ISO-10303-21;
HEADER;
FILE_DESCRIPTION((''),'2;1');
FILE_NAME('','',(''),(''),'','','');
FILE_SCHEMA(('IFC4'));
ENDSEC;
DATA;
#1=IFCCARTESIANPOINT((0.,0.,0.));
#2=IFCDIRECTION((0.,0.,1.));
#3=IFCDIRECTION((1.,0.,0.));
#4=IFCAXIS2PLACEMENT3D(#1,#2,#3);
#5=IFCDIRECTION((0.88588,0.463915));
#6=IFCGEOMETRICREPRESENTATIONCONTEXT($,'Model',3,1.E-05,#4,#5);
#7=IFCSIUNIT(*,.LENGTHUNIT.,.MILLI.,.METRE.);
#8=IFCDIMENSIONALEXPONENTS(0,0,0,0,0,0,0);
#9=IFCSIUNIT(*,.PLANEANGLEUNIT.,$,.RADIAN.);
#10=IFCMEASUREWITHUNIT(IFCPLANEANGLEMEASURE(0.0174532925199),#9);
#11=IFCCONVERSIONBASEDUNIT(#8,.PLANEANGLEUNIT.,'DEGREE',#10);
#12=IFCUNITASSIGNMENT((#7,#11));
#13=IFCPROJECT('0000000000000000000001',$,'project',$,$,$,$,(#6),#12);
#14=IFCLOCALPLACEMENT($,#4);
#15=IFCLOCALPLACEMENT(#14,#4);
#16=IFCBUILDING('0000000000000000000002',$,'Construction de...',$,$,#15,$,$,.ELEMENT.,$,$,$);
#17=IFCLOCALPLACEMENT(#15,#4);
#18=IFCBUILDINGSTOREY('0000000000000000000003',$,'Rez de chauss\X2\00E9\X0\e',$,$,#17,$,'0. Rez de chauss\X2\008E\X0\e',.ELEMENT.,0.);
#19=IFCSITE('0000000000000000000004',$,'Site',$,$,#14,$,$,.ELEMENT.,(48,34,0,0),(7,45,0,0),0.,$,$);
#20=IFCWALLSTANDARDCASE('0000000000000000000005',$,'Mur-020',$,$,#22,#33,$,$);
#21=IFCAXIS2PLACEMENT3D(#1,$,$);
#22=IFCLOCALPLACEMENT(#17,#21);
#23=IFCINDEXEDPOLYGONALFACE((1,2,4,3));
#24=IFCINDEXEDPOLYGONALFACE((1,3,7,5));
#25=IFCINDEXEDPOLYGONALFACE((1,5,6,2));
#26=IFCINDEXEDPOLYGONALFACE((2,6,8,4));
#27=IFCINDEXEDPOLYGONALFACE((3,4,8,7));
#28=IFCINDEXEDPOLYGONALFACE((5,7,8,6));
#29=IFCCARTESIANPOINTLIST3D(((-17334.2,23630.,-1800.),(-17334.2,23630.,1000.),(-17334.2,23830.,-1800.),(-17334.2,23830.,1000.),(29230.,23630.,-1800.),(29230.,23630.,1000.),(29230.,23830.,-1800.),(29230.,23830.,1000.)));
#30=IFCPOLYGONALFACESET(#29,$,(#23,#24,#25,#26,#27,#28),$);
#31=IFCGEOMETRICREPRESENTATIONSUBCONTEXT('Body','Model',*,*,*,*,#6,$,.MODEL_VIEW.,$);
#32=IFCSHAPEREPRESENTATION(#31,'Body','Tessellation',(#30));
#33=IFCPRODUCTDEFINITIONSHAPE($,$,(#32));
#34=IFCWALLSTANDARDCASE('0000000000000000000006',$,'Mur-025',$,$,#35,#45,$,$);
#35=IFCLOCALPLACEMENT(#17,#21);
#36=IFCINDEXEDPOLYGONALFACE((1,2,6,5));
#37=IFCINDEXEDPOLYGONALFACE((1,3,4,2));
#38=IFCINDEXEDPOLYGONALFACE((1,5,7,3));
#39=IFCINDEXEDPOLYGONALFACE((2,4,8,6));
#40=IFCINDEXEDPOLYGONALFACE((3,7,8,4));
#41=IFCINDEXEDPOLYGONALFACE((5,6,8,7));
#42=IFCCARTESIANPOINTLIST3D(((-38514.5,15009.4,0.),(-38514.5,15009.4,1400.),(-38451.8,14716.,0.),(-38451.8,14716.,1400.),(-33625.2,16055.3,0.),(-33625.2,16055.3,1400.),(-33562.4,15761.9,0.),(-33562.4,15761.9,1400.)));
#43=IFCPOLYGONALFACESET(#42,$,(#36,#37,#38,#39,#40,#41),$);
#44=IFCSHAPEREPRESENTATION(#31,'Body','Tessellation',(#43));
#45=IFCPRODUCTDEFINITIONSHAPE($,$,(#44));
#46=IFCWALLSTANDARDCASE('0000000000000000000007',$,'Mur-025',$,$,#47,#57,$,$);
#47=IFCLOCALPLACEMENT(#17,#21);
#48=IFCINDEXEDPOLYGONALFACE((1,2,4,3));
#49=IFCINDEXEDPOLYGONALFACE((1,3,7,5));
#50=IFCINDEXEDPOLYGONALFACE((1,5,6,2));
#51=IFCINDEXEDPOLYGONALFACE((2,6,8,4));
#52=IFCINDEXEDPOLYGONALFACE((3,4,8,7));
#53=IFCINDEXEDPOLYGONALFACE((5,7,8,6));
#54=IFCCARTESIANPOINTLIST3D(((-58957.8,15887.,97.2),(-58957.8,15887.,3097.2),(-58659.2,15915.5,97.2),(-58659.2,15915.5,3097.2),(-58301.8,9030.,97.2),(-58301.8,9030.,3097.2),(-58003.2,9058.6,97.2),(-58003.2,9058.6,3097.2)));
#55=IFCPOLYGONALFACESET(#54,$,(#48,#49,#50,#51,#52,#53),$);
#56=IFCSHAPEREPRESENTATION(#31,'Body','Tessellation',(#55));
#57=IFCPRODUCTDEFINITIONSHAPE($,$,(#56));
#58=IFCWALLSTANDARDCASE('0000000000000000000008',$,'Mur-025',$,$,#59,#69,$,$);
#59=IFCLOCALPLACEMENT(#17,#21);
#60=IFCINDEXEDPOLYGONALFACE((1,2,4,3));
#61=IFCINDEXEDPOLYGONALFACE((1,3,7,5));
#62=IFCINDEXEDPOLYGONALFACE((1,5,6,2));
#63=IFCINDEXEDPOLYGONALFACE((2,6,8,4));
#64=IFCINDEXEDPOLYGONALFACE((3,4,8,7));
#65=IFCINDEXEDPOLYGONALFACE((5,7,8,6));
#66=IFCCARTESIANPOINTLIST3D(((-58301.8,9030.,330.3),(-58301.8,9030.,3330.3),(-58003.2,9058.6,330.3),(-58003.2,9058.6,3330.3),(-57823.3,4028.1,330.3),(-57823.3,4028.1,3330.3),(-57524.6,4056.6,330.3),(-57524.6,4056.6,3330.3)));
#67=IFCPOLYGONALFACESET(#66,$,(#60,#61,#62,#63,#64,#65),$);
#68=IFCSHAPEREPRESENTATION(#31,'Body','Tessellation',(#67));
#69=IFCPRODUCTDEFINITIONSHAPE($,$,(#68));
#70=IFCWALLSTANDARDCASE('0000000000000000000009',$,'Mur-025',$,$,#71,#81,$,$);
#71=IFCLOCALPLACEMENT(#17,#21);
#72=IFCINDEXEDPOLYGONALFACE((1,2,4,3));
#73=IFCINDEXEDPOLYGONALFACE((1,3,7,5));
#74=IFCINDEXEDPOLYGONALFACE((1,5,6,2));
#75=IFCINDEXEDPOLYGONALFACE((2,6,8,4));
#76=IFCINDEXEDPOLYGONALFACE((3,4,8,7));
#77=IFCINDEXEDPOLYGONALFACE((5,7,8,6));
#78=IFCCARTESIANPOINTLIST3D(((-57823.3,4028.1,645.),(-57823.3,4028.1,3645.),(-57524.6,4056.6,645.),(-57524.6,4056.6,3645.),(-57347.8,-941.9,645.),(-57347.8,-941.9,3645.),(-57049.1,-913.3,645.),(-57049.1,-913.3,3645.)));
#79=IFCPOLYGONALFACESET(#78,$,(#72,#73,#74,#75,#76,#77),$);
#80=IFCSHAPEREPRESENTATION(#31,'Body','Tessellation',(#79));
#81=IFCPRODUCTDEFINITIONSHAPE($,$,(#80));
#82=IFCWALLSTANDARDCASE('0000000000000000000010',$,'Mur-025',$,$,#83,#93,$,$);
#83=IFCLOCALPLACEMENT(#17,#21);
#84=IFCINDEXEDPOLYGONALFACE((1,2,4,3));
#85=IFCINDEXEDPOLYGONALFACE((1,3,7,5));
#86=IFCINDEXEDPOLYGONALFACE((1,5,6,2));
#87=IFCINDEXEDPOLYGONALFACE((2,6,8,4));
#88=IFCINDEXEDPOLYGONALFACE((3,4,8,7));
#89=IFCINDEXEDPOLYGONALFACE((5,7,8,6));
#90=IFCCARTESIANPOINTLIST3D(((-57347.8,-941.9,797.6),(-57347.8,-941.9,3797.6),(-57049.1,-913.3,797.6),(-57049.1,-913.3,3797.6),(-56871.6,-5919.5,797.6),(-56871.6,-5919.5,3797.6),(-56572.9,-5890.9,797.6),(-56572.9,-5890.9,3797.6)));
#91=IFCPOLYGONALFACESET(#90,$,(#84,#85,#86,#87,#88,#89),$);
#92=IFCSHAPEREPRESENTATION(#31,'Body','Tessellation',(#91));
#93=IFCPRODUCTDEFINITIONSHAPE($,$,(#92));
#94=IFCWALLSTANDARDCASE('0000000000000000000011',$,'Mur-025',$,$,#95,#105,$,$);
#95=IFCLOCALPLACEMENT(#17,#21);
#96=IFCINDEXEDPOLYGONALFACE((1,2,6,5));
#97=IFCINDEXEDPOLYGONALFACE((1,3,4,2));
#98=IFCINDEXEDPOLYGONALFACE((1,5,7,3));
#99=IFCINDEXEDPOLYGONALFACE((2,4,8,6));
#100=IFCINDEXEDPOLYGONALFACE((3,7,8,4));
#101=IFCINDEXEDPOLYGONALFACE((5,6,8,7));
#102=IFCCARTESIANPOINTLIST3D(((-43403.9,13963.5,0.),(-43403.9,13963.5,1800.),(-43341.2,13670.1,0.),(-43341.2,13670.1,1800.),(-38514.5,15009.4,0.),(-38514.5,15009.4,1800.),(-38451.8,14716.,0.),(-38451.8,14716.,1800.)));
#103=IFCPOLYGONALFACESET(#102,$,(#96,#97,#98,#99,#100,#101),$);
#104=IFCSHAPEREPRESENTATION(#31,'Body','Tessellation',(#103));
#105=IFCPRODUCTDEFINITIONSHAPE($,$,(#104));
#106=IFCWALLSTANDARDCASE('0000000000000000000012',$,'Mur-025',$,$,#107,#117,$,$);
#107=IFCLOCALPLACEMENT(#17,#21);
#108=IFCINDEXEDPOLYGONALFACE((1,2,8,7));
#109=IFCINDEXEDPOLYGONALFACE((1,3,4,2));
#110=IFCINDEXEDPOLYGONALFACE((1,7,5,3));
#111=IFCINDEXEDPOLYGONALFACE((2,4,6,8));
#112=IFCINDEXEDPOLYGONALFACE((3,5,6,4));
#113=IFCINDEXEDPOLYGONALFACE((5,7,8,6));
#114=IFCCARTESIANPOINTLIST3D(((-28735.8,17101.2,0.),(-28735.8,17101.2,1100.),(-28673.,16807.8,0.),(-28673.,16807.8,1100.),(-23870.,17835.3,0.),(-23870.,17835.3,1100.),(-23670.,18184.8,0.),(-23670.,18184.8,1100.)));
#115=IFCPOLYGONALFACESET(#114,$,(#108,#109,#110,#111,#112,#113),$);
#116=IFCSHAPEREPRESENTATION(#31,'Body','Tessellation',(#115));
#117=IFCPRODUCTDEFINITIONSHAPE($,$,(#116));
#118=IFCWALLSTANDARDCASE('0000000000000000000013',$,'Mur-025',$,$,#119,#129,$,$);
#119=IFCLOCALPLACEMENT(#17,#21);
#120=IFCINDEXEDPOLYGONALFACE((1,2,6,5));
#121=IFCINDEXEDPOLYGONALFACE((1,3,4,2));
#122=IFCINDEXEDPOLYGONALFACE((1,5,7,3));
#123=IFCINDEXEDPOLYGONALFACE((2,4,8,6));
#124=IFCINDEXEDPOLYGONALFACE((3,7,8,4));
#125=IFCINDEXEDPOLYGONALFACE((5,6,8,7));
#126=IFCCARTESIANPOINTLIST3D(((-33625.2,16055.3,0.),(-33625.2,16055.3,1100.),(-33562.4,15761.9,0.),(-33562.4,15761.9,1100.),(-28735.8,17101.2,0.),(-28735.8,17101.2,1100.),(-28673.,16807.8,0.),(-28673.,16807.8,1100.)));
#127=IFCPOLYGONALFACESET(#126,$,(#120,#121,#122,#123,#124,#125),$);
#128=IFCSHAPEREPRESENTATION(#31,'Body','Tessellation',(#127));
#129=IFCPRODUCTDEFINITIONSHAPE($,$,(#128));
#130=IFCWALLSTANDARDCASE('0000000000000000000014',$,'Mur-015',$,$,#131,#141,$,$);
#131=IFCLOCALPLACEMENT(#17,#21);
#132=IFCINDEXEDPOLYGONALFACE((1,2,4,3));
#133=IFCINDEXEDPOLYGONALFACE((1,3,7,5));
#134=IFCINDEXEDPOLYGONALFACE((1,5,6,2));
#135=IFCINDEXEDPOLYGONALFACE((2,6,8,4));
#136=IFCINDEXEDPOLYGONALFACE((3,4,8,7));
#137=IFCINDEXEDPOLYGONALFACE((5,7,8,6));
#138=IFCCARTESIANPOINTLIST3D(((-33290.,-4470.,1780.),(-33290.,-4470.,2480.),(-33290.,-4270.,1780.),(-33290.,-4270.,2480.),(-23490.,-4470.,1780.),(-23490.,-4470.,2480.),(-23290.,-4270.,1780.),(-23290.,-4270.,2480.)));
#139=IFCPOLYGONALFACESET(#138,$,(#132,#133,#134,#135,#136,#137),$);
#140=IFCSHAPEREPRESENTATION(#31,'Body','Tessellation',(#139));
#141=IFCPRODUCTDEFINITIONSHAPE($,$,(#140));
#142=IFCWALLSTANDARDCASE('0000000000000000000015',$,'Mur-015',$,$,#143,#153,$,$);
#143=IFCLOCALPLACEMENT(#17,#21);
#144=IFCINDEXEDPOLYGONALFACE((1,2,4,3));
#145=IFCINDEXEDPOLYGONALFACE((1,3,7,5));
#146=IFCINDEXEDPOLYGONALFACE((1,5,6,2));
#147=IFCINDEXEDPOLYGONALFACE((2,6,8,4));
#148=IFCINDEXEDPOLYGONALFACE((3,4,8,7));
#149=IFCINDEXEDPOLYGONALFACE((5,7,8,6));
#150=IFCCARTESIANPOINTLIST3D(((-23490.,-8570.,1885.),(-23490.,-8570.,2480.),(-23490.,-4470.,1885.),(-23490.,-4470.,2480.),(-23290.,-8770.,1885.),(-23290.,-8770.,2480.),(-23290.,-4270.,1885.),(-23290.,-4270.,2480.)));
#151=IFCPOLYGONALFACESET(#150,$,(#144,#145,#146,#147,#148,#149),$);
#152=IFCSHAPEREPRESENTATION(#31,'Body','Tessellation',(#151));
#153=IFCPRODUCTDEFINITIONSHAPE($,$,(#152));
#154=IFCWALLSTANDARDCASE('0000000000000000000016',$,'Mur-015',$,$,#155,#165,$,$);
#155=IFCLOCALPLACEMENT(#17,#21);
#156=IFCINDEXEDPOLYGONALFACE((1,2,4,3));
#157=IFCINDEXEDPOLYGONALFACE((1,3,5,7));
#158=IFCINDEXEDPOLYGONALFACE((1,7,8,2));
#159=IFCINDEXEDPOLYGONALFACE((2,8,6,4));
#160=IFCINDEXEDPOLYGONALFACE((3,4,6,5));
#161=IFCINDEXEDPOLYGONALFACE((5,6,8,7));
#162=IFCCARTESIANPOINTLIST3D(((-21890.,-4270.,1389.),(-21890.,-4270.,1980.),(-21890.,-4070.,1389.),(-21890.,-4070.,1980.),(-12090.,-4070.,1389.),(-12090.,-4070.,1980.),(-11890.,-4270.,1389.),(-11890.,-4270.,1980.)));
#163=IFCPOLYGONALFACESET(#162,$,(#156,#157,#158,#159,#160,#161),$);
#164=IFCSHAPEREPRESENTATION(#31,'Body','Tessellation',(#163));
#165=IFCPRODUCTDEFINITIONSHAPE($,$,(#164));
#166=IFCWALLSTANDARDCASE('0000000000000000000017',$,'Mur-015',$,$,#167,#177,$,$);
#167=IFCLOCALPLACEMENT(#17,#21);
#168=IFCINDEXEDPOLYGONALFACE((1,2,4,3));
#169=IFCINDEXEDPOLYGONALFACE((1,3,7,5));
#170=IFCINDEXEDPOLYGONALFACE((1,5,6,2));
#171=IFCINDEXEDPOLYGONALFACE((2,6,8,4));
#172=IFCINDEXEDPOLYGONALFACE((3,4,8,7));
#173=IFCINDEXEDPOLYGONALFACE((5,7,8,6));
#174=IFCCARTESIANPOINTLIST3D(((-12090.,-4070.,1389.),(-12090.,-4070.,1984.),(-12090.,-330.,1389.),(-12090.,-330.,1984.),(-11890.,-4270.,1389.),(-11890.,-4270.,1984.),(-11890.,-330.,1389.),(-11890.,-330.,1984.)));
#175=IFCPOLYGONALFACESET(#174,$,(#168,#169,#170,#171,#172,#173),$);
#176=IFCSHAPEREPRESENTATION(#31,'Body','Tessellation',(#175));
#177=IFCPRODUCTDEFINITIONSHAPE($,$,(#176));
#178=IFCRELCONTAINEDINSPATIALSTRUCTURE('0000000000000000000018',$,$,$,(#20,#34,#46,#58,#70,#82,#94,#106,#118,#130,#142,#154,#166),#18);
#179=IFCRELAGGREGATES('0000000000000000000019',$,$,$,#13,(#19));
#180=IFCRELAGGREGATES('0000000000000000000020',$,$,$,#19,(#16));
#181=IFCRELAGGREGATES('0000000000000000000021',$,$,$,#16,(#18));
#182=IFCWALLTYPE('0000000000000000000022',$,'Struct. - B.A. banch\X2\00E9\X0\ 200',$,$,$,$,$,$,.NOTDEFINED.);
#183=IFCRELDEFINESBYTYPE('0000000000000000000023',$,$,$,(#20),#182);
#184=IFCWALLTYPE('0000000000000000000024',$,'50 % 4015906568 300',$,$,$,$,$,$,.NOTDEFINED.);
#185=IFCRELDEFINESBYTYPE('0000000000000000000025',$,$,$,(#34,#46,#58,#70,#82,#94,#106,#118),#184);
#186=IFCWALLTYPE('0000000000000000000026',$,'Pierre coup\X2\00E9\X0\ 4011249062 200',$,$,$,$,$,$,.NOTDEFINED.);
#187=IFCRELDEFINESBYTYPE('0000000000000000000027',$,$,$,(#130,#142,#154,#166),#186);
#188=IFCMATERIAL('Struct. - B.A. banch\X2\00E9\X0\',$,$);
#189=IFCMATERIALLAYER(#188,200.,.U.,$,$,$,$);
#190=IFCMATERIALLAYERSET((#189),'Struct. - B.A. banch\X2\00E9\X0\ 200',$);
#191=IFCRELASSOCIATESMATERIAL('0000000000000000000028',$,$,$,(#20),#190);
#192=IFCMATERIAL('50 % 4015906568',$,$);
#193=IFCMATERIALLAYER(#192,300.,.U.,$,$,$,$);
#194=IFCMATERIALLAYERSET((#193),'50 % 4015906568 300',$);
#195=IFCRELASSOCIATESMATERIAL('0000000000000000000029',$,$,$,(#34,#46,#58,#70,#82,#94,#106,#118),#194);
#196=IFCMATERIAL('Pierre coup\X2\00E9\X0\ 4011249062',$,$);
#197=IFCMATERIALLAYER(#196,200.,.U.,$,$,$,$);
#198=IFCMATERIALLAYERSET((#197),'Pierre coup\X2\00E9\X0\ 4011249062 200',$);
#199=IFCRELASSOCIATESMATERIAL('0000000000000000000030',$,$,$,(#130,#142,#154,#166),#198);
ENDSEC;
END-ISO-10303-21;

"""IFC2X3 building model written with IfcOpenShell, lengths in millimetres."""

from ifc_helpers import new_model, entity, si_unit, converted_unit, direction, frame, origin_with_axes, place, context, subcontext, project, spatial, polyline, outline, extrude, material, layer, layer_set, layer_usage, type_object, element, save


model = new_model("IFC2X3")

# Units and contexts
model_context = context("Model", 3, precision=1e-05, world=origin_with_axes(), true_north=direction((0.88588, 0.463915)))
body_context = subcontext(model_context, "Body", "Model", "MODEL_VIEW")
ifc_project = project(units=[si_unit("LENGTHUNIT", "METRE", prefix="MILLI"), converted_unit("PLANEANGLEUNIT", "DEGREE", entity("IfcPlaneAngleMeasure", 0.0174532925199), si_unit("PLANEANGLEUNIT", "RADIAN"), dimensions=[0, 0, 0, 0, 0, 0, 0])], contexts=[model_context])

# Site, building, storey
site_placement = place(None, origin_with_axes())
site = spatial("IfcSite", under=ifc_project, at=site_placement, Name="Site", CompositionType="ELEMENT", RefLatitude=(48, 34, 0, 0), RefLongitude=(7, 45, 0, 0), RefElevation=0.0)
building_placement = place(site_placement, origin_with_axes())
building = spatial("IfcBuilding", under=site, at=building_placement, Name="Construction de...", CompositionType="ELEMENT")
storey_placement = place(building_placement, origin_with_axes())
storey = spatial("IfcBuildingStorey", under=building, at=storey_placement, Name="Rez de chaussée", LongName="0. Rez de chauss\u008ee", CompositionType="ELEMENT", Elevation=0.0)

# Walls
ifc_material_1 = material(Name="Struct. - B.A. banché")
ifc_layer_1 = layer(ifc_material_1, 200.0, ventilated="UNKNOWN")
ifc_layer_set_1 = layer_set([ifc_layer_1], Name="Struct. - B.A. banché 200")
wall_type_1 = type_object("IfcWallType", Name="Struct. - B.A. banché 200", PredefinedType="NOTDEFINED")
ifc_layer_usage_1 = layer_usage(ifc_layer_set_1, "AXIS2", "NEGATIVE", 100.0)
wall_1_placement = place(storey_placement, frame((-17334.2, 23730.0, -1800.0), z_axis=(0.0, 0.0, 1.0), x_axis=(1.0, 0.0, 0.0)))
element("IfcWallStandardCase", 1, at=wall_1_placement, inside=storey, type_object=wall_type_1, material=ifc_layer_usage_1, Name="Mur-020", context=body_context, shape_type="SweptSolid", body=[
    extrude(outline(polyline([(0.0, -100.0), (46564.2, -100.0), (46564.2, 100.0), (0.0, 100.0), (0.0, -100.0)])), origin_with_axes(), (0.0, 0.0, 1.0), 2800.0),
])
ifc_material_2 = material(Name="50 % 4015906568")
ifc_layer_2 = layer(ifc_material_2, 300.0, ventilated="UNKNOWN")
ifc_layer_set_2 = layer_set([ifc_layer_2], Name="50 % 4015906568 300")
ifc_layer_usage_2 = layer_usage(ifc_layer_set_2, "AXIS2", "NEGATIVE", 150.0)
wall_type_2 = type_object("IfcWallType", Name="50 % 4015906568 300", PredefinedType="NOTDEFINED")
wall_2_placement = place(storey_placement, frame((-38483.2, 14862.7, 0.0), z_axis=(0.0, 0.0, 1.0), x_axis=(0.977877, 0.209182, 0.0)))
element("IfcWallStandardCase", 2, at=wall_2_placement, inside=storey, type_object=wall_type_2, material=ifc_layer_usage_2, Name="Mur-025", context=body_context, shape_type="SweptSolid", body=[
    extrude(outline(polyline([(0.0, -150.0), (5000.0, -150.0), (5000.0, 150.0), (0.0, 150.0), (0.0, -150.0)])), origin_with_axes(), (0.0, 0.0, 1.0), 1400.0),
])
ifc_layer_usage_3 = layer_usage(ifc_layer_set_2, "AXIS2", "NEGATIVE", 150.0)
wall_3_placement = place(storey_placement, frame((-58808.5, 15901.2, 97.2), z_axis=(0.0, 0.0, 1.0), x_axis=(0.095235, -0.995455, 0.0)))
element("IfcWallStandardCase", 3, at=wall_3_placement, inside=storey, type_object=wall_type_2, material=ifc_layer_usage_3, Name="Mur-025", context=body_context, shape_type="SweptSolid", body=[
    extrude(outline(polyline([(0.0, -150.0), (6888.2, -150.0), (6888.2, 150.0), (0.0, 150.0), (0.0, -150.0)])), origin_with_axes(), (0.0, 0.0, 1.0), 3000.0),
])
ifc_layer_usage_4 = layer_usage(ifc_layer_set_2, "AXIS2", "NEGATIVE", 150.0)
wall_4_placement = place(storey_placement, frame((-58152.5, 9044.3, 330.3), z_axis=(0.0, 0.0, 1.0), x_axis=(0.095235, -0.995455, 0.0)))
element("IfcWallStandardCase", 4, at=wall_4_placement, inside=storey, type_object=wall_type_2, material=ifc_layer_usage_4, Name="Mur-025", context=body_context, shape_type="SweptSolid", body=[
    extrude(outline(polyline([(0.0, -150.0), (5024.8, -150.0), (5024.8, 150.0), (0.0, 150.0), (0.0, -150.0)])), origin_with_axes(), (0.0, 0.0, 1.0), 3000.0),
])
ifc_layer_usage_5 = layer_usage(ifc_layer_set_2, "AXIS2", "NEGATIVE", 150.0)
wall_5_placement = place(storey_placement, frame((-57673.9, 4042.3, 645.0), z_axis=(0.0, 0.0, 1.0), x_axis=(0.095235, -0.995455, 0.0)))
element("IfcWallStandardCase", 5, at=wall_5_placement, inside=storey, type_object=wall_type_2, material=ifc_layer_usage_5, Name="Mur-025", context=body_context, shape_type="SweptSolid", body=[
    extrude(outline(polyline([(0.0, -150.0), (4992.7, -150.0), (4992.7, 150.0), (0.0, 150.0), (0.0, -150.0)])), origin_with_axes(), (0.0, 0.0, 1.0), 3000.0),
])
ifc_layer_usage_6 = layer_usage(ifc_layer_set_2, "AXIS2", "NEGATIVE", 150.0)
wall_6_placement = place(storey_placement, frame((-57198.5, -927.6, 797.6), z_axis=(0.0, 0.0, 1.0), x_axis=(0.095235, -0.995455, 0.0)))
element("IfcWallStandardCase", 6, at=wall_6_placement, inside=storey, type_object=wall_type_2, material=ifc_layer_usage_6, Name="Mur-025", context=body_context, shape_type="SweptSolid", body=[
    extrude(outline(polyline([(0.0, -150.0), (5000.3, -150.0), (5000.3, 150.0), (0.0, 150.0), (0.0, -150.0)])), origin_with_axes(), (0.0, 0.0, 1.0), 3000.0),
])
ifc_layer_usage_7 = layer_usage(ifc_layer_set_2, "AXIS2", "NEGATIVE", 150.0)
wall_7_placement = place(storey_placement, frame((-43372.5, 13816.8, 0.0), z_axis=(0.0, 0.0, 1.0), x_axis=(0.977877, 0.209182, 0.0)))
element("IfcWallStandardCase", 7, at=wall_7_placement, inside=storey, type_object=wall_type_2, material=ifc_layer_usage_7, Name="Mur-025", context=body_context, shape_type="SweptSolid", body=[
    extrude(outline(polyline([(0.0, -150.0), (5000.0, -150.0), (5000.0, 150.0), (0.0, 150.0), (0.0, -150.0)])), origin_with_axes(), (0.0, 0.0, 1.0), 1800.0),
])
ifc_layer_usage_8 = layer_usage(ifc_layer_set_2, "AXIS2", "NEGATIVE", 150.0)
wall_8_placement = place(storey_placement, frame((-28704.4, 16954.5, 0.0), z_axis=(0.0, 0.0, 1.0), x_axis=(0.977877, 0.209182, 0.0)))
element("IfcWallStandardCase", 8, at=wall_8_placement, inside=storey, type_object=wall_type_2, material=ifc_layer_usage_8, Name="Mur-025", context=body_context, shape_type="SweptSolid", body=[
    extrude(outline(polyline([(0.0, -150.0), (4911.7, -150.0), (5180.4, 150.0), (0.0, 150.0), (0.0, -150.0)])), origin_with_axes(), (0.0, 0.0, 1.0), 1100.0),
])
ifc_layer_usage_9 = layer_usage(ifc_layer_set_2, "AXIS2", "NEGATIVE", 150.0)
wall_9_placement = place(storey_placement, frame((-33593.8, 15908.6, 0.0), z_axis=(0.0, 0.0, 1.0), x_axis=(0.977877, 0.209182, 0.0)))
element("IfcWallStandardCase", 9, at=wall_9_placement, inside=storey, type_object=wall_type_2, material=ifc_layer_usage_9, Name="Mur-025", context=body_context, shape_type="SweptSolid", body=[
    extrude(outline(polyline([(0.0, -150.0), (5000.0, -150.0), (5000.0, 150.0), (0.0, 150.0), (0.0, -150.0)])), origin_with_axes(), (0.0, 0.0, 1.0), 1100.0),
])
ifc_material_3 = material(Name="Pierre coupé 4011249062")
ifc_layer_3 = layer(ifc_material_3, 200.0, ventilated="UNKNOWN")
ifc_layer_set_3 = layer_set([ifc_layer_3], Name="Pierre coupé 4011249062 200")
ifc_layer_usage_10 = layer_usage(ifc_layer_set_3, "AXIS2", "NEGATIVE", 100.0)
wall_type_3 = type_object("IfcWallType", Name="Pierre coupé 4011249062 200", PredefinedType="NOTDEFINED")
wall_10_placement = place(storey_placement, frame((-33290.0, -4370.0, 1780.0), z_axis=(0.0, 0.0, 1.0), x_axis=(1.0, 0.0, 0.0)))
element("IfcWallStandardCase", 10, at=wall_10_placement, inside=storey, type_object=wall_type_3, material=ifc_layer_usage_10, Name="Mur-015", context=body_context, shape_type="SweptSolid", body=[
    extrude(outline(polyline([(0.0, -100.0), (9800.0, -100.0), (10000.0, 100.0), (0.0, 100.0), (0.0, -100.0)])), origin_with_axes(), (0.0, 0.0, 1.0), 700.0),
])
ifc_layer_usage_11 = layer_usage(ifc_layer_set_3, "AXIS2", "POSITIVE", -100.0)
wall_11_placement = place(storey_placement, frame((-23390.0, -4370.0, 1885.0), z_axis=(0.0, 0.0, 1.0), x_axis=(0.0, -1.0, 0.0)))
element("IfcWallStandardCase", 11, at=wall_11_placement, inside=storey, type_object=wall_type_3, material=ifc_layer_usage_11, Name="Mur-015", context=body_context, shape_type="SweptSolid", body=[
    extrude(outline(polyline([(100.0, -100.0), (4200.0, -100.0), (4400.0, 100.0), (-100.0, 100.0), (100.0, -100.0)])), origin_with_axes(), (0.0, 0.0, 1.0), 595.0),
])
ifc_layer_usage_12 = layer_usage(ifc_layer_set_3, "AXIS2", "NEGATIVE", 100.0)
wall_12_placement = place(storey_placement, frame((-21890.0, -4170.0, 1389.0), z_axis=(0.0, 0.0, 1.0), x_axis=(1.0, 0.0, 0.0)))
element("IfcWallStandardCase", 12, at=wall_12_placement, inside=storey, type_object=wall_type_3, material=ifc_layer_usage_12, Name="Mur-015", context=body_context, shape_type="SweptSolid", body=[
    extrude(outline(polyline([(0.0, -100.0), (10000.0, -100.0), (9800.0, 100.0), (0.0, 100.0), (0.0, -100.0)])), origin_with_axes(), (0.0, 0.0, 1.0), 591.0),
])
ifc_layer_usage_13 = layer_usage(ifc_layer_set_3, "AXIS2", "POSITIVE", -100.0)
wall_13_placement = place(storey_placement, frame((-11990.0, -230.0, 1389.0), z_axis=(0.0, 0.0, 1.0), x_axis=(0.0, -1.0, 0.0)))
element("IfcWallStandardCase", 13, at=wall_13_placement, inside=storey, type_object=wall_type_3, material=ifc_layer_usage_13, Name="Mur-015", context=body_context, shape_type="SweptSolid", body=[
    extrude(outline(polyline([(100.0, -100.0), (3840.0, -100.0), (4040.0, 100.0), (100.0, 100.0), (100.0, -100.0)])), origin_with_axes(), (0.0, 0.0, 1.0), 595.0),
])

save(model, "model.ifc")
